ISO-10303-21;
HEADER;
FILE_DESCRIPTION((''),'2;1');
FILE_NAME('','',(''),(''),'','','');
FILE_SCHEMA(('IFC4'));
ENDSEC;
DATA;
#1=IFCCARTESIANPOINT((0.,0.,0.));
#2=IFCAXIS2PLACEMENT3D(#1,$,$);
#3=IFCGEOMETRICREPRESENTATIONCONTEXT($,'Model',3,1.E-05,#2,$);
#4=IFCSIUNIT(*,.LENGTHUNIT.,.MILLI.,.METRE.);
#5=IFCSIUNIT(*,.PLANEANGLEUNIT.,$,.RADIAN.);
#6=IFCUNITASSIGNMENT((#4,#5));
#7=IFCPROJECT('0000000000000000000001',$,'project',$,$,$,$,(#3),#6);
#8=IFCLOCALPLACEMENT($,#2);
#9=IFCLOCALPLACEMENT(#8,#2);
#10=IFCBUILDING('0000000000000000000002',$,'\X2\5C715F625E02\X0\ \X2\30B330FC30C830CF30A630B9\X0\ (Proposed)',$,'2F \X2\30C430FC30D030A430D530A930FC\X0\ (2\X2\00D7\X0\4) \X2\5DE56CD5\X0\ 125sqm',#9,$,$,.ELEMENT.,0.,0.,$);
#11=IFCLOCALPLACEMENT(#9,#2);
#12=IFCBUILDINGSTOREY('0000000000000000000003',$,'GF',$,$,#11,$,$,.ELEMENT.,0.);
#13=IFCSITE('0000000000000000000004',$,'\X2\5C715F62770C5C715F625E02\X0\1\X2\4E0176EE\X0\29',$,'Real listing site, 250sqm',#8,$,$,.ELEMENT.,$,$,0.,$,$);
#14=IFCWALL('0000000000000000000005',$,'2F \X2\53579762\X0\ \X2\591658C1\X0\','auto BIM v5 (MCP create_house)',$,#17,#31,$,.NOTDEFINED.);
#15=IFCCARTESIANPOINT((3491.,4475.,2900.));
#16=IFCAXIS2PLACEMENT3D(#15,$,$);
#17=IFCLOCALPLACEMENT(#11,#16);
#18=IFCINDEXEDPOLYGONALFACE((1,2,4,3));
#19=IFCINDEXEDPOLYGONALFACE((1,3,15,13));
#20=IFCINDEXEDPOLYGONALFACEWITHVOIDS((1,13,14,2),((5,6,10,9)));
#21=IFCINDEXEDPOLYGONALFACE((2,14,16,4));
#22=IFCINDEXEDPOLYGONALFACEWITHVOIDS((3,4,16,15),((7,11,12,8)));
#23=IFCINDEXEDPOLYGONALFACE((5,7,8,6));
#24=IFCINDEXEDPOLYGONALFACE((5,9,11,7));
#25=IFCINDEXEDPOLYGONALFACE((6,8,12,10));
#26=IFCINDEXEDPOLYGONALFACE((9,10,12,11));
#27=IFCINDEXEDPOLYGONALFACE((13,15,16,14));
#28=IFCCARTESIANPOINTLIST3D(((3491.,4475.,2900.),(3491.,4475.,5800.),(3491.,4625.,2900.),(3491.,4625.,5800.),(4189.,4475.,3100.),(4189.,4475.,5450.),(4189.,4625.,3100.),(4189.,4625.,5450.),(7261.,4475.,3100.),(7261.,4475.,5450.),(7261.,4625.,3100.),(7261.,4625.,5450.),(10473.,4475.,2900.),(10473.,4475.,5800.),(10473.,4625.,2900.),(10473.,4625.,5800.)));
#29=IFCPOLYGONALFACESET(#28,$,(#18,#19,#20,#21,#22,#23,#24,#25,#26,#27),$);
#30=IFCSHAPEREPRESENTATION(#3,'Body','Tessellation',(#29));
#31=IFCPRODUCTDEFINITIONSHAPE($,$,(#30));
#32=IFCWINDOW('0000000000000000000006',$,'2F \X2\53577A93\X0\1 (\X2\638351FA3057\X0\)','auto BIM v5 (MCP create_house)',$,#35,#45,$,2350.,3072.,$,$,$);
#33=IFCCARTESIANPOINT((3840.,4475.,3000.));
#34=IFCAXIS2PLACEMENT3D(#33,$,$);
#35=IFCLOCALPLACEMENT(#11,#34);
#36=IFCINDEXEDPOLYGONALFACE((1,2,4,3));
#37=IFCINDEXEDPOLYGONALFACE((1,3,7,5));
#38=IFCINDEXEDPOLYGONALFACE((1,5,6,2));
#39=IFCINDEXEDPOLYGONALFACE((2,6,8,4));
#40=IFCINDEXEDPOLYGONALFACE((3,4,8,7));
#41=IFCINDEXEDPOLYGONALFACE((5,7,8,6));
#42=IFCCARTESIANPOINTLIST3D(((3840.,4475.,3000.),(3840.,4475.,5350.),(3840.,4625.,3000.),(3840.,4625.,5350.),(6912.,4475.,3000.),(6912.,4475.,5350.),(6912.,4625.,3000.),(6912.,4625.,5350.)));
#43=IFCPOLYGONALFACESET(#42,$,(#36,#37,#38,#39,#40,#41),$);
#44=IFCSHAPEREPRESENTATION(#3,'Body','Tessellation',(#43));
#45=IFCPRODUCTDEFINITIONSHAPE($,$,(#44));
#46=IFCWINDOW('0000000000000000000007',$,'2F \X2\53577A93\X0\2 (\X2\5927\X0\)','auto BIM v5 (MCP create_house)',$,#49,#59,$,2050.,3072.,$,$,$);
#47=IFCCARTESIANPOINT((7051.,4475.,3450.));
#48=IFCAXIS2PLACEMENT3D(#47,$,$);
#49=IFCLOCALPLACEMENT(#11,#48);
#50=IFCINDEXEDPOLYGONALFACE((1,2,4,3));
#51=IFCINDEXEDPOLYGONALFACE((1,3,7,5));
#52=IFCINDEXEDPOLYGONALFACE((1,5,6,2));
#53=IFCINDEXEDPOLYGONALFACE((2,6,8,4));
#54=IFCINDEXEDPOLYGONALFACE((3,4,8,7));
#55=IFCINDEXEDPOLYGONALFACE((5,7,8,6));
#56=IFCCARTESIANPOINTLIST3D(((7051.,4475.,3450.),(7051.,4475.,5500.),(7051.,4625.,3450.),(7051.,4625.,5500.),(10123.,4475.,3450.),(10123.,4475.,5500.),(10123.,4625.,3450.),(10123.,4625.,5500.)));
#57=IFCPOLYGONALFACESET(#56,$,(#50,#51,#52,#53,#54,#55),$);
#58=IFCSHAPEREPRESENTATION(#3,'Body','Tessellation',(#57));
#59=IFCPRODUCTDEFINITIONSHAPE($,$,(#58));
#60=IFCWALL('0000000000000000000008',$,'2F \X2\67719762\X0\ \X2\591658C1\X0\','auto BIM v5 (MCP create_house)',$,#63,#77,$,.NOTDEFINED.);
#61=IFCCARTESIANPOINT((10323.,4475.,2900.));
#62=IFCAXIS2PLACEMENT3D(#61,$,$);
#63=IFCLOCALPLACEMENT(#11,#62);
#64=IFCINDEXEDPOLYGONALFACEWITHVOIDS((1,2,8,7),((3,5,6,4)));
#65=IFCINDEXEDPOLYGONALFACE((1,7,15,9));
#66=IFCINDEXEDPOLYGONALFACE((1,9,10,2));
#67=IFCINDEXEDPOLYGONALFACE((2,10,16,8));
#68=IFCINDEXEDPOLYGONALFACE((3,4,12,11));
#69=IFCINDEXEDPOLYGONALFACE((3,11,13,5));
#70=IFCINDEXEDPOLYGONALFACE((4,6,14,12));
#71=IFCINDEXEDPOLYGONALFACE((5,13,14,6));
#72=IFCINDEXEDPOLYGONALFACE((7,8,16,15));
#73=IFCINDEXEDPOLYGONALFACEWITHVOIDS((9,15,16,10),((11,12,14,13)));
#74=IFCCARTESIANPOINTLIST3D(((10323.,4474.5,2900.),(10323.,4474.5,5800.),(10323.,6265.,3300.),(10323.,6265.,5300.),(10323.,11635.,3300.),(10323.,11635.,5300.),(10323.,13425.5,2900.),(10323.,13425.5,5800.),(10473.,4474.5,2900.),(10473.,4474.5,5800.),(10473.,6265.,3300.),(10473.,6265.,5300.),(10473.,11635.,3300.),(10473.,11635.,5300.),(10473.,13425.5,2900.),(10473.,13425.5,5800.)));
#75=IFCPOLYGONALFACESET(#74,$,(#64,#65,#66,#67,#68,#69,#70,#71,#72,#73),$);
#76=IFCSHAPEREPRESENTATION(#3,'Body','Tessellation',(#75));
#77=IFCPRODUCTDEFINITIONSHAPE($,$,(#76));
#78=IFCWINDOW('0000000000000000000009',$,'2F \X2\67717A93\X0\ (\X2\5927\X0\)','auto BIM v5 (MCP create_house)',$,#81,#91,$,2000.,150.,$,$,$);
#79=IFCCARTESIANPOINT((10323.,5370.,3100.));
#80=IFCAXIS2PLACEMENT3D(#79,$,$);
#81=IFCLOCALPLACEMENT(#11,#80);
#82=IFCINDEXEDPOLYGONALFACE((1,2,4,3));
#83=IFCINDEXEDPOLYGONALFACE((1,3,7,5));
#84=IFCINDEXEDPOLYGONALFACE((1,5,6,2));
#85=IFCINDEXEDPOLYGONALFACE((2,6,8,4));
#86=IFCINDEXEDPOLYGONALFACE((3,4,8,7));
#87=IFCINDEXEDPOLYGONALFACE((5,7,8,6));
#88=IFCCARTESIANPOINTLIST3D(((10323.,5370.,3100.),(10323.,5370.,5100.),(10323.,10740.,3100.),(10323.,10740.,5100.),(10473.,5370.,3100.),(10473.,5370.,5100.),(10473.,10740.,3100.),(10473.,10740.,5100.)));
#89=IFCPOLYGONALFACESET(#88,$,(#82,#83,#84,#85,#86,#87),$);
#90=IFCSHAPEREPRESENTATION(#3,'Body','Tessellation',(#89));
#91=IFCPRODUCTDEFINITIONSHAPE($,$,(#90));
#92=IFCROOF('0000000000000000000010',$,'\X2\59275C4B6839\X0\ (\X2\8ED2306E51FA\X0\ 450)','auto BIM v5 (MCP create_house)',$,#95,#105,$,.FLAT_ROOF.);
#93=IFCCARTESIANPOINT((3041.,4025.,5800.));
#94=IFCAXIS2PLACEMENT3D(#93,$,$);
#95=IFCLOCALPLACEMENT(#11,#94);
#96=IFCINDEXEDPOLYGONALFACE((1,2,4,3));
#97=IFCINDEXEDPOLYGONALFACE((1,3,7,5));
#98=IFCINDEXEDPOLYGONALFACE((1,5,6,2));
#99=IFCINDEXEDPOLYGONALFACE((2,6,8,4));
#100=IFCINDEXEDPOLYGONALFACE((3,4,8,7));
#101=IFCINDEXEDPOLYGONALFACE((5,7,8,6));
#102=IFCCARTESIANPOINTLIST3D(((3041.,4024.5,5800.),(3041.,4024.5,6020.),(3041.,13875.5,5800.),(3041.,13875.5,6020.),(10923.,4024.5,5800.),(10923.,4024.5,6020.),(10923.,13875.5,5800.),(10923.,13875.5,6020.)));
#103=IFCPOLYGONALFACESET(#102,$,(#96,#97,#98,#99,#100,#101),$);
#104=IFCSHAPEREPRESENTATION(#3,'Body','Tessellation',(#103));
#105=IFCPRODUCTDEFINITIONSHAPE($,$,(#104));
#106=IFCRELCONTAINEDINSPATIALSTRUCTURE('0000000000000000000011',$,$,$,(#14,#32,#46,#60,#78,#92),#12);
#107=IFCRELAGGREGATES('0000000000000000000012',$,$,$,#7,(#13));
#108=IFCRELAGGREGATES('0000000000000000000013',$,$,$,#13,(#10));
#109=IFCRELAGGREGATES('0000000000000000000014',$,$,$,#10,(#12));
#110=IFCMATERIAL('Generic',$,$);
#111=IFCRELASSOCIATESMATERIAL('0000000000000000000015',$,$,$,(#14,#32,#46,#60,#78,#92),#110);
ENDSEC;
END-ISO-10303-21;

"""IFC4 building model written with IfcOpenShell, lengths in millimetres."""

from ifc_helpers import new_model, si_unit, frame, frame_2d, origin, place, context, project, spatial, rectangle, extrude, material, element, fill, save


model = new_model("IFC4")

# Units and contexts
model_context = context("Model", 3, precision=1e-05, world=origin())
ifc_project = project(units=[si_unit("LENGTHUNIT", "METRE", prefix="MILLI"), si_unit("PLANEANGLEUNIT", "RADIAN")], contexts=[model_context])

# Site, building, storey
site_placement = place(None, origin())
site = spatial("IfcSite", under=ifc_project, at=site_placement, Name="山形県山形市1丁目29", ObjectType="Real listing site, 250sqm", CompositionType="ELEMENT", RefElevation=0.0)
building_placement = place(site_placement, origin())
building = spatial("IfcBuilding", under=site, at=building_placement, Name="山形市 コートハウス (Proposed)", ObjectType="2F ツーバイフォー (2×4) 工法 125sqm", CompositionType="ELEMENT", ElevationOfRefHeight=0.0, ElevationOfTerrain=0.0)
storey_placement = place(building_placement, origin())
storey = spatial("IfcBuildingStorey", under=building, at=storey_placement, Name="GF", CompositionType="ELEMENT", Elevation=0.0)

# Shared definitions
ifc_material = material(Name="Generic")

# Wall, openings, windows
wall_1_placement = place(storey_placement, frame((3491.0, 4475.0, 2900.0)))
wall_1 = element("IfcWall", 1, at=wall_1_placement, inside=storey, material=ifc_material, Name="2F 南面 外壁", Description="auto BIM v5 (MCP create_house)", PredefinedType="NOTDEFINED", context=model_context, shape_type="SweptSolid", body=[
    extrude(rectangle(XDim=6982.0, YDim=150.0, at=frame_2d((3491.0, 75.0))), frame((3491.0, 4475.0, 2900.0)), (0.0, 0.0, 1.0), 2900.0),
])
opening_1_placement = place(storey_placement, frame((3840.0, 4475.0, 3000.0)))
opening_1 = element("IfcOpeningElement", 2, at=opening_1_placement, cuts=wall_1, PredefinedType="NOTDEFINED", context=model_context, shape_type="SweptSolid", body=[
    extrude(rectangle(XDim=3072.0, YDim=150.0, at=frame_2d((1536.0, 75.0))), frame((3840.0, 4475.0, 3000.0)), (0.0, 0.0, 1.0), 2350.0),
])
opening_2_placement = place(storey_placement, frame((7051.0, 4475.0, 3450.0)))
opening_2 = element("IfcOpeningElement", 3, at=opening_2_placement, cuts=wall_1, PredefinedType="NOTDEFINED", context=model_context, shape_type="SweptSolid", body=[
    extrude(rectangle(XDim=3072.0, YDim=150.0, at=frame_2d((1536.0, 75.0))), frame((7051.0, 4475.0, 3450.0)), (0.0, 0.0, 1.0), 2050.0),
])
window_1_placement = place(storey_placement, frame((3840.0, 4475.0, 3000.0)))
window_1 = element("IfcWindow", 4, at=window_1_placement, inside=storey, material=ifc_material, Name="2F 南窓1 (掃出し)", Description="auto BIM v5 (MCP create_house)", OverallHeight=2350.0, OverallWidth=3072.0, context=model_context, shape_type="SweptSolid", body=[
    extrude(rectangle(XDim=3072.0, YDim=150.0, at=frame_2d((1536.0, 75.0))), frame((3840.0, 4475.0, 3000.0)), (0.0, 0.0, 1.0), 2350.0),
])
fill(opening_1, window_1)
window_2_placement = place(storey_placement, frame((7051.0, 4475.0, 3450.0)))
window_2 = element("IfcWindow", 5, at=window_2_placement, inside=storey, material=ifc_material, Name="2F 南窓2 (大)", Description="auto BIM v5 (MCP create_house)", OverallHeight=2050.0, OverallWidth=3072.0, context=model_context, shape_type="SweptSolid", body=[
    extrude(rectangle(XDim=3072.0, YDim=150.0, at=frame_2d((1536.0, 75.0))), frame((7051.0, 4475.0, 3450.0)), (0.0, 0.0, 1.0), 2050.0),
])
fill(opening_2, window_2)

# Wall, opening, window
wall_2_placement = place(storey_placement, frame((10323.0, 4475.0, 2900.0)))
wall_2 = element("IfcWall", 6, at=wall_2_placement, inside=storey, material=ifc_material, Name="2F 東面 外壁", Description="auto BIM v5 (MCP create_house)", PredefinedType="NOTDEFINED", context=model_context, shape_type="SweptSolid", body=[
    extrude(rectangle(XDim=150.0, YDim=8951.0, at=frame_2d((75.0, 4475.0))), frame((10323.0, 4475.0, 2900.0)), (0.0, 0.0, 1.0), 2900.0),
])
opening_3_placement = place(storey_placement, frame((10323.0, 5370.0, 3100.0)))
opening_3 = element("IfcOpeningElement", 7, at=opening_3_placement, cuts=wall_2, PredefinedType="NOTDEFINED", context=model_context, shape_type="SweptSolid", body=[
    extrude(rectangle(XDim=150.0, YDim=5370.0, at=frame_2d((75.0, 2685.0))), frame((10323.0, 5370.0, 3100.0)), (0.0, 0.0, 1.0), 2000.0),
])
window_3_placement = place(storey_placement, frame((10323.0, 5370.0, 3100.0)))
window_3 = element("IfcWindow", 8, at=window_3_placement, inside=storey, material=ifc_material, Name="2F 東窓 (大)", Description="auto BIM v5 (MCP create_house)", OverallHeight=2000.0, OverallWidth=150.0, context=model_context, shape_type="SweptSolid", body=[
    extrude(rectangle(XDim=150.0, YDim=5370.0, at=frame_2d((75.0, 2685.0))), frame((10323.0, 5370.0, 3100.0)), (0.0, 0.0, 1.0), 2000.0),
])
fill(opening_3, window_3)

# Roof
roof_placement = place(storey_placement, frame((3041.0, 4025.0, 5800.0)))
element("IfcRoof", 9, at=roof_placement, inside=storey, material=ifc_material, Name="大屋根 (軒の出 450)", Description="auto BIM v5 (MCP create_house)", PredefinedType="FLAT_ROOF", context=model_context, shape_type="SweptSolid", body=[
    extrude(rectangle(XDim=7882.0, YDim=9851.0, at=frame_2d((3941.0, 4925.0))), frame((3041.0, 4025.0, 5800.0)), (0.0, 0.0, 1.0), 220.0),
])

save(model, "model.ifc")
